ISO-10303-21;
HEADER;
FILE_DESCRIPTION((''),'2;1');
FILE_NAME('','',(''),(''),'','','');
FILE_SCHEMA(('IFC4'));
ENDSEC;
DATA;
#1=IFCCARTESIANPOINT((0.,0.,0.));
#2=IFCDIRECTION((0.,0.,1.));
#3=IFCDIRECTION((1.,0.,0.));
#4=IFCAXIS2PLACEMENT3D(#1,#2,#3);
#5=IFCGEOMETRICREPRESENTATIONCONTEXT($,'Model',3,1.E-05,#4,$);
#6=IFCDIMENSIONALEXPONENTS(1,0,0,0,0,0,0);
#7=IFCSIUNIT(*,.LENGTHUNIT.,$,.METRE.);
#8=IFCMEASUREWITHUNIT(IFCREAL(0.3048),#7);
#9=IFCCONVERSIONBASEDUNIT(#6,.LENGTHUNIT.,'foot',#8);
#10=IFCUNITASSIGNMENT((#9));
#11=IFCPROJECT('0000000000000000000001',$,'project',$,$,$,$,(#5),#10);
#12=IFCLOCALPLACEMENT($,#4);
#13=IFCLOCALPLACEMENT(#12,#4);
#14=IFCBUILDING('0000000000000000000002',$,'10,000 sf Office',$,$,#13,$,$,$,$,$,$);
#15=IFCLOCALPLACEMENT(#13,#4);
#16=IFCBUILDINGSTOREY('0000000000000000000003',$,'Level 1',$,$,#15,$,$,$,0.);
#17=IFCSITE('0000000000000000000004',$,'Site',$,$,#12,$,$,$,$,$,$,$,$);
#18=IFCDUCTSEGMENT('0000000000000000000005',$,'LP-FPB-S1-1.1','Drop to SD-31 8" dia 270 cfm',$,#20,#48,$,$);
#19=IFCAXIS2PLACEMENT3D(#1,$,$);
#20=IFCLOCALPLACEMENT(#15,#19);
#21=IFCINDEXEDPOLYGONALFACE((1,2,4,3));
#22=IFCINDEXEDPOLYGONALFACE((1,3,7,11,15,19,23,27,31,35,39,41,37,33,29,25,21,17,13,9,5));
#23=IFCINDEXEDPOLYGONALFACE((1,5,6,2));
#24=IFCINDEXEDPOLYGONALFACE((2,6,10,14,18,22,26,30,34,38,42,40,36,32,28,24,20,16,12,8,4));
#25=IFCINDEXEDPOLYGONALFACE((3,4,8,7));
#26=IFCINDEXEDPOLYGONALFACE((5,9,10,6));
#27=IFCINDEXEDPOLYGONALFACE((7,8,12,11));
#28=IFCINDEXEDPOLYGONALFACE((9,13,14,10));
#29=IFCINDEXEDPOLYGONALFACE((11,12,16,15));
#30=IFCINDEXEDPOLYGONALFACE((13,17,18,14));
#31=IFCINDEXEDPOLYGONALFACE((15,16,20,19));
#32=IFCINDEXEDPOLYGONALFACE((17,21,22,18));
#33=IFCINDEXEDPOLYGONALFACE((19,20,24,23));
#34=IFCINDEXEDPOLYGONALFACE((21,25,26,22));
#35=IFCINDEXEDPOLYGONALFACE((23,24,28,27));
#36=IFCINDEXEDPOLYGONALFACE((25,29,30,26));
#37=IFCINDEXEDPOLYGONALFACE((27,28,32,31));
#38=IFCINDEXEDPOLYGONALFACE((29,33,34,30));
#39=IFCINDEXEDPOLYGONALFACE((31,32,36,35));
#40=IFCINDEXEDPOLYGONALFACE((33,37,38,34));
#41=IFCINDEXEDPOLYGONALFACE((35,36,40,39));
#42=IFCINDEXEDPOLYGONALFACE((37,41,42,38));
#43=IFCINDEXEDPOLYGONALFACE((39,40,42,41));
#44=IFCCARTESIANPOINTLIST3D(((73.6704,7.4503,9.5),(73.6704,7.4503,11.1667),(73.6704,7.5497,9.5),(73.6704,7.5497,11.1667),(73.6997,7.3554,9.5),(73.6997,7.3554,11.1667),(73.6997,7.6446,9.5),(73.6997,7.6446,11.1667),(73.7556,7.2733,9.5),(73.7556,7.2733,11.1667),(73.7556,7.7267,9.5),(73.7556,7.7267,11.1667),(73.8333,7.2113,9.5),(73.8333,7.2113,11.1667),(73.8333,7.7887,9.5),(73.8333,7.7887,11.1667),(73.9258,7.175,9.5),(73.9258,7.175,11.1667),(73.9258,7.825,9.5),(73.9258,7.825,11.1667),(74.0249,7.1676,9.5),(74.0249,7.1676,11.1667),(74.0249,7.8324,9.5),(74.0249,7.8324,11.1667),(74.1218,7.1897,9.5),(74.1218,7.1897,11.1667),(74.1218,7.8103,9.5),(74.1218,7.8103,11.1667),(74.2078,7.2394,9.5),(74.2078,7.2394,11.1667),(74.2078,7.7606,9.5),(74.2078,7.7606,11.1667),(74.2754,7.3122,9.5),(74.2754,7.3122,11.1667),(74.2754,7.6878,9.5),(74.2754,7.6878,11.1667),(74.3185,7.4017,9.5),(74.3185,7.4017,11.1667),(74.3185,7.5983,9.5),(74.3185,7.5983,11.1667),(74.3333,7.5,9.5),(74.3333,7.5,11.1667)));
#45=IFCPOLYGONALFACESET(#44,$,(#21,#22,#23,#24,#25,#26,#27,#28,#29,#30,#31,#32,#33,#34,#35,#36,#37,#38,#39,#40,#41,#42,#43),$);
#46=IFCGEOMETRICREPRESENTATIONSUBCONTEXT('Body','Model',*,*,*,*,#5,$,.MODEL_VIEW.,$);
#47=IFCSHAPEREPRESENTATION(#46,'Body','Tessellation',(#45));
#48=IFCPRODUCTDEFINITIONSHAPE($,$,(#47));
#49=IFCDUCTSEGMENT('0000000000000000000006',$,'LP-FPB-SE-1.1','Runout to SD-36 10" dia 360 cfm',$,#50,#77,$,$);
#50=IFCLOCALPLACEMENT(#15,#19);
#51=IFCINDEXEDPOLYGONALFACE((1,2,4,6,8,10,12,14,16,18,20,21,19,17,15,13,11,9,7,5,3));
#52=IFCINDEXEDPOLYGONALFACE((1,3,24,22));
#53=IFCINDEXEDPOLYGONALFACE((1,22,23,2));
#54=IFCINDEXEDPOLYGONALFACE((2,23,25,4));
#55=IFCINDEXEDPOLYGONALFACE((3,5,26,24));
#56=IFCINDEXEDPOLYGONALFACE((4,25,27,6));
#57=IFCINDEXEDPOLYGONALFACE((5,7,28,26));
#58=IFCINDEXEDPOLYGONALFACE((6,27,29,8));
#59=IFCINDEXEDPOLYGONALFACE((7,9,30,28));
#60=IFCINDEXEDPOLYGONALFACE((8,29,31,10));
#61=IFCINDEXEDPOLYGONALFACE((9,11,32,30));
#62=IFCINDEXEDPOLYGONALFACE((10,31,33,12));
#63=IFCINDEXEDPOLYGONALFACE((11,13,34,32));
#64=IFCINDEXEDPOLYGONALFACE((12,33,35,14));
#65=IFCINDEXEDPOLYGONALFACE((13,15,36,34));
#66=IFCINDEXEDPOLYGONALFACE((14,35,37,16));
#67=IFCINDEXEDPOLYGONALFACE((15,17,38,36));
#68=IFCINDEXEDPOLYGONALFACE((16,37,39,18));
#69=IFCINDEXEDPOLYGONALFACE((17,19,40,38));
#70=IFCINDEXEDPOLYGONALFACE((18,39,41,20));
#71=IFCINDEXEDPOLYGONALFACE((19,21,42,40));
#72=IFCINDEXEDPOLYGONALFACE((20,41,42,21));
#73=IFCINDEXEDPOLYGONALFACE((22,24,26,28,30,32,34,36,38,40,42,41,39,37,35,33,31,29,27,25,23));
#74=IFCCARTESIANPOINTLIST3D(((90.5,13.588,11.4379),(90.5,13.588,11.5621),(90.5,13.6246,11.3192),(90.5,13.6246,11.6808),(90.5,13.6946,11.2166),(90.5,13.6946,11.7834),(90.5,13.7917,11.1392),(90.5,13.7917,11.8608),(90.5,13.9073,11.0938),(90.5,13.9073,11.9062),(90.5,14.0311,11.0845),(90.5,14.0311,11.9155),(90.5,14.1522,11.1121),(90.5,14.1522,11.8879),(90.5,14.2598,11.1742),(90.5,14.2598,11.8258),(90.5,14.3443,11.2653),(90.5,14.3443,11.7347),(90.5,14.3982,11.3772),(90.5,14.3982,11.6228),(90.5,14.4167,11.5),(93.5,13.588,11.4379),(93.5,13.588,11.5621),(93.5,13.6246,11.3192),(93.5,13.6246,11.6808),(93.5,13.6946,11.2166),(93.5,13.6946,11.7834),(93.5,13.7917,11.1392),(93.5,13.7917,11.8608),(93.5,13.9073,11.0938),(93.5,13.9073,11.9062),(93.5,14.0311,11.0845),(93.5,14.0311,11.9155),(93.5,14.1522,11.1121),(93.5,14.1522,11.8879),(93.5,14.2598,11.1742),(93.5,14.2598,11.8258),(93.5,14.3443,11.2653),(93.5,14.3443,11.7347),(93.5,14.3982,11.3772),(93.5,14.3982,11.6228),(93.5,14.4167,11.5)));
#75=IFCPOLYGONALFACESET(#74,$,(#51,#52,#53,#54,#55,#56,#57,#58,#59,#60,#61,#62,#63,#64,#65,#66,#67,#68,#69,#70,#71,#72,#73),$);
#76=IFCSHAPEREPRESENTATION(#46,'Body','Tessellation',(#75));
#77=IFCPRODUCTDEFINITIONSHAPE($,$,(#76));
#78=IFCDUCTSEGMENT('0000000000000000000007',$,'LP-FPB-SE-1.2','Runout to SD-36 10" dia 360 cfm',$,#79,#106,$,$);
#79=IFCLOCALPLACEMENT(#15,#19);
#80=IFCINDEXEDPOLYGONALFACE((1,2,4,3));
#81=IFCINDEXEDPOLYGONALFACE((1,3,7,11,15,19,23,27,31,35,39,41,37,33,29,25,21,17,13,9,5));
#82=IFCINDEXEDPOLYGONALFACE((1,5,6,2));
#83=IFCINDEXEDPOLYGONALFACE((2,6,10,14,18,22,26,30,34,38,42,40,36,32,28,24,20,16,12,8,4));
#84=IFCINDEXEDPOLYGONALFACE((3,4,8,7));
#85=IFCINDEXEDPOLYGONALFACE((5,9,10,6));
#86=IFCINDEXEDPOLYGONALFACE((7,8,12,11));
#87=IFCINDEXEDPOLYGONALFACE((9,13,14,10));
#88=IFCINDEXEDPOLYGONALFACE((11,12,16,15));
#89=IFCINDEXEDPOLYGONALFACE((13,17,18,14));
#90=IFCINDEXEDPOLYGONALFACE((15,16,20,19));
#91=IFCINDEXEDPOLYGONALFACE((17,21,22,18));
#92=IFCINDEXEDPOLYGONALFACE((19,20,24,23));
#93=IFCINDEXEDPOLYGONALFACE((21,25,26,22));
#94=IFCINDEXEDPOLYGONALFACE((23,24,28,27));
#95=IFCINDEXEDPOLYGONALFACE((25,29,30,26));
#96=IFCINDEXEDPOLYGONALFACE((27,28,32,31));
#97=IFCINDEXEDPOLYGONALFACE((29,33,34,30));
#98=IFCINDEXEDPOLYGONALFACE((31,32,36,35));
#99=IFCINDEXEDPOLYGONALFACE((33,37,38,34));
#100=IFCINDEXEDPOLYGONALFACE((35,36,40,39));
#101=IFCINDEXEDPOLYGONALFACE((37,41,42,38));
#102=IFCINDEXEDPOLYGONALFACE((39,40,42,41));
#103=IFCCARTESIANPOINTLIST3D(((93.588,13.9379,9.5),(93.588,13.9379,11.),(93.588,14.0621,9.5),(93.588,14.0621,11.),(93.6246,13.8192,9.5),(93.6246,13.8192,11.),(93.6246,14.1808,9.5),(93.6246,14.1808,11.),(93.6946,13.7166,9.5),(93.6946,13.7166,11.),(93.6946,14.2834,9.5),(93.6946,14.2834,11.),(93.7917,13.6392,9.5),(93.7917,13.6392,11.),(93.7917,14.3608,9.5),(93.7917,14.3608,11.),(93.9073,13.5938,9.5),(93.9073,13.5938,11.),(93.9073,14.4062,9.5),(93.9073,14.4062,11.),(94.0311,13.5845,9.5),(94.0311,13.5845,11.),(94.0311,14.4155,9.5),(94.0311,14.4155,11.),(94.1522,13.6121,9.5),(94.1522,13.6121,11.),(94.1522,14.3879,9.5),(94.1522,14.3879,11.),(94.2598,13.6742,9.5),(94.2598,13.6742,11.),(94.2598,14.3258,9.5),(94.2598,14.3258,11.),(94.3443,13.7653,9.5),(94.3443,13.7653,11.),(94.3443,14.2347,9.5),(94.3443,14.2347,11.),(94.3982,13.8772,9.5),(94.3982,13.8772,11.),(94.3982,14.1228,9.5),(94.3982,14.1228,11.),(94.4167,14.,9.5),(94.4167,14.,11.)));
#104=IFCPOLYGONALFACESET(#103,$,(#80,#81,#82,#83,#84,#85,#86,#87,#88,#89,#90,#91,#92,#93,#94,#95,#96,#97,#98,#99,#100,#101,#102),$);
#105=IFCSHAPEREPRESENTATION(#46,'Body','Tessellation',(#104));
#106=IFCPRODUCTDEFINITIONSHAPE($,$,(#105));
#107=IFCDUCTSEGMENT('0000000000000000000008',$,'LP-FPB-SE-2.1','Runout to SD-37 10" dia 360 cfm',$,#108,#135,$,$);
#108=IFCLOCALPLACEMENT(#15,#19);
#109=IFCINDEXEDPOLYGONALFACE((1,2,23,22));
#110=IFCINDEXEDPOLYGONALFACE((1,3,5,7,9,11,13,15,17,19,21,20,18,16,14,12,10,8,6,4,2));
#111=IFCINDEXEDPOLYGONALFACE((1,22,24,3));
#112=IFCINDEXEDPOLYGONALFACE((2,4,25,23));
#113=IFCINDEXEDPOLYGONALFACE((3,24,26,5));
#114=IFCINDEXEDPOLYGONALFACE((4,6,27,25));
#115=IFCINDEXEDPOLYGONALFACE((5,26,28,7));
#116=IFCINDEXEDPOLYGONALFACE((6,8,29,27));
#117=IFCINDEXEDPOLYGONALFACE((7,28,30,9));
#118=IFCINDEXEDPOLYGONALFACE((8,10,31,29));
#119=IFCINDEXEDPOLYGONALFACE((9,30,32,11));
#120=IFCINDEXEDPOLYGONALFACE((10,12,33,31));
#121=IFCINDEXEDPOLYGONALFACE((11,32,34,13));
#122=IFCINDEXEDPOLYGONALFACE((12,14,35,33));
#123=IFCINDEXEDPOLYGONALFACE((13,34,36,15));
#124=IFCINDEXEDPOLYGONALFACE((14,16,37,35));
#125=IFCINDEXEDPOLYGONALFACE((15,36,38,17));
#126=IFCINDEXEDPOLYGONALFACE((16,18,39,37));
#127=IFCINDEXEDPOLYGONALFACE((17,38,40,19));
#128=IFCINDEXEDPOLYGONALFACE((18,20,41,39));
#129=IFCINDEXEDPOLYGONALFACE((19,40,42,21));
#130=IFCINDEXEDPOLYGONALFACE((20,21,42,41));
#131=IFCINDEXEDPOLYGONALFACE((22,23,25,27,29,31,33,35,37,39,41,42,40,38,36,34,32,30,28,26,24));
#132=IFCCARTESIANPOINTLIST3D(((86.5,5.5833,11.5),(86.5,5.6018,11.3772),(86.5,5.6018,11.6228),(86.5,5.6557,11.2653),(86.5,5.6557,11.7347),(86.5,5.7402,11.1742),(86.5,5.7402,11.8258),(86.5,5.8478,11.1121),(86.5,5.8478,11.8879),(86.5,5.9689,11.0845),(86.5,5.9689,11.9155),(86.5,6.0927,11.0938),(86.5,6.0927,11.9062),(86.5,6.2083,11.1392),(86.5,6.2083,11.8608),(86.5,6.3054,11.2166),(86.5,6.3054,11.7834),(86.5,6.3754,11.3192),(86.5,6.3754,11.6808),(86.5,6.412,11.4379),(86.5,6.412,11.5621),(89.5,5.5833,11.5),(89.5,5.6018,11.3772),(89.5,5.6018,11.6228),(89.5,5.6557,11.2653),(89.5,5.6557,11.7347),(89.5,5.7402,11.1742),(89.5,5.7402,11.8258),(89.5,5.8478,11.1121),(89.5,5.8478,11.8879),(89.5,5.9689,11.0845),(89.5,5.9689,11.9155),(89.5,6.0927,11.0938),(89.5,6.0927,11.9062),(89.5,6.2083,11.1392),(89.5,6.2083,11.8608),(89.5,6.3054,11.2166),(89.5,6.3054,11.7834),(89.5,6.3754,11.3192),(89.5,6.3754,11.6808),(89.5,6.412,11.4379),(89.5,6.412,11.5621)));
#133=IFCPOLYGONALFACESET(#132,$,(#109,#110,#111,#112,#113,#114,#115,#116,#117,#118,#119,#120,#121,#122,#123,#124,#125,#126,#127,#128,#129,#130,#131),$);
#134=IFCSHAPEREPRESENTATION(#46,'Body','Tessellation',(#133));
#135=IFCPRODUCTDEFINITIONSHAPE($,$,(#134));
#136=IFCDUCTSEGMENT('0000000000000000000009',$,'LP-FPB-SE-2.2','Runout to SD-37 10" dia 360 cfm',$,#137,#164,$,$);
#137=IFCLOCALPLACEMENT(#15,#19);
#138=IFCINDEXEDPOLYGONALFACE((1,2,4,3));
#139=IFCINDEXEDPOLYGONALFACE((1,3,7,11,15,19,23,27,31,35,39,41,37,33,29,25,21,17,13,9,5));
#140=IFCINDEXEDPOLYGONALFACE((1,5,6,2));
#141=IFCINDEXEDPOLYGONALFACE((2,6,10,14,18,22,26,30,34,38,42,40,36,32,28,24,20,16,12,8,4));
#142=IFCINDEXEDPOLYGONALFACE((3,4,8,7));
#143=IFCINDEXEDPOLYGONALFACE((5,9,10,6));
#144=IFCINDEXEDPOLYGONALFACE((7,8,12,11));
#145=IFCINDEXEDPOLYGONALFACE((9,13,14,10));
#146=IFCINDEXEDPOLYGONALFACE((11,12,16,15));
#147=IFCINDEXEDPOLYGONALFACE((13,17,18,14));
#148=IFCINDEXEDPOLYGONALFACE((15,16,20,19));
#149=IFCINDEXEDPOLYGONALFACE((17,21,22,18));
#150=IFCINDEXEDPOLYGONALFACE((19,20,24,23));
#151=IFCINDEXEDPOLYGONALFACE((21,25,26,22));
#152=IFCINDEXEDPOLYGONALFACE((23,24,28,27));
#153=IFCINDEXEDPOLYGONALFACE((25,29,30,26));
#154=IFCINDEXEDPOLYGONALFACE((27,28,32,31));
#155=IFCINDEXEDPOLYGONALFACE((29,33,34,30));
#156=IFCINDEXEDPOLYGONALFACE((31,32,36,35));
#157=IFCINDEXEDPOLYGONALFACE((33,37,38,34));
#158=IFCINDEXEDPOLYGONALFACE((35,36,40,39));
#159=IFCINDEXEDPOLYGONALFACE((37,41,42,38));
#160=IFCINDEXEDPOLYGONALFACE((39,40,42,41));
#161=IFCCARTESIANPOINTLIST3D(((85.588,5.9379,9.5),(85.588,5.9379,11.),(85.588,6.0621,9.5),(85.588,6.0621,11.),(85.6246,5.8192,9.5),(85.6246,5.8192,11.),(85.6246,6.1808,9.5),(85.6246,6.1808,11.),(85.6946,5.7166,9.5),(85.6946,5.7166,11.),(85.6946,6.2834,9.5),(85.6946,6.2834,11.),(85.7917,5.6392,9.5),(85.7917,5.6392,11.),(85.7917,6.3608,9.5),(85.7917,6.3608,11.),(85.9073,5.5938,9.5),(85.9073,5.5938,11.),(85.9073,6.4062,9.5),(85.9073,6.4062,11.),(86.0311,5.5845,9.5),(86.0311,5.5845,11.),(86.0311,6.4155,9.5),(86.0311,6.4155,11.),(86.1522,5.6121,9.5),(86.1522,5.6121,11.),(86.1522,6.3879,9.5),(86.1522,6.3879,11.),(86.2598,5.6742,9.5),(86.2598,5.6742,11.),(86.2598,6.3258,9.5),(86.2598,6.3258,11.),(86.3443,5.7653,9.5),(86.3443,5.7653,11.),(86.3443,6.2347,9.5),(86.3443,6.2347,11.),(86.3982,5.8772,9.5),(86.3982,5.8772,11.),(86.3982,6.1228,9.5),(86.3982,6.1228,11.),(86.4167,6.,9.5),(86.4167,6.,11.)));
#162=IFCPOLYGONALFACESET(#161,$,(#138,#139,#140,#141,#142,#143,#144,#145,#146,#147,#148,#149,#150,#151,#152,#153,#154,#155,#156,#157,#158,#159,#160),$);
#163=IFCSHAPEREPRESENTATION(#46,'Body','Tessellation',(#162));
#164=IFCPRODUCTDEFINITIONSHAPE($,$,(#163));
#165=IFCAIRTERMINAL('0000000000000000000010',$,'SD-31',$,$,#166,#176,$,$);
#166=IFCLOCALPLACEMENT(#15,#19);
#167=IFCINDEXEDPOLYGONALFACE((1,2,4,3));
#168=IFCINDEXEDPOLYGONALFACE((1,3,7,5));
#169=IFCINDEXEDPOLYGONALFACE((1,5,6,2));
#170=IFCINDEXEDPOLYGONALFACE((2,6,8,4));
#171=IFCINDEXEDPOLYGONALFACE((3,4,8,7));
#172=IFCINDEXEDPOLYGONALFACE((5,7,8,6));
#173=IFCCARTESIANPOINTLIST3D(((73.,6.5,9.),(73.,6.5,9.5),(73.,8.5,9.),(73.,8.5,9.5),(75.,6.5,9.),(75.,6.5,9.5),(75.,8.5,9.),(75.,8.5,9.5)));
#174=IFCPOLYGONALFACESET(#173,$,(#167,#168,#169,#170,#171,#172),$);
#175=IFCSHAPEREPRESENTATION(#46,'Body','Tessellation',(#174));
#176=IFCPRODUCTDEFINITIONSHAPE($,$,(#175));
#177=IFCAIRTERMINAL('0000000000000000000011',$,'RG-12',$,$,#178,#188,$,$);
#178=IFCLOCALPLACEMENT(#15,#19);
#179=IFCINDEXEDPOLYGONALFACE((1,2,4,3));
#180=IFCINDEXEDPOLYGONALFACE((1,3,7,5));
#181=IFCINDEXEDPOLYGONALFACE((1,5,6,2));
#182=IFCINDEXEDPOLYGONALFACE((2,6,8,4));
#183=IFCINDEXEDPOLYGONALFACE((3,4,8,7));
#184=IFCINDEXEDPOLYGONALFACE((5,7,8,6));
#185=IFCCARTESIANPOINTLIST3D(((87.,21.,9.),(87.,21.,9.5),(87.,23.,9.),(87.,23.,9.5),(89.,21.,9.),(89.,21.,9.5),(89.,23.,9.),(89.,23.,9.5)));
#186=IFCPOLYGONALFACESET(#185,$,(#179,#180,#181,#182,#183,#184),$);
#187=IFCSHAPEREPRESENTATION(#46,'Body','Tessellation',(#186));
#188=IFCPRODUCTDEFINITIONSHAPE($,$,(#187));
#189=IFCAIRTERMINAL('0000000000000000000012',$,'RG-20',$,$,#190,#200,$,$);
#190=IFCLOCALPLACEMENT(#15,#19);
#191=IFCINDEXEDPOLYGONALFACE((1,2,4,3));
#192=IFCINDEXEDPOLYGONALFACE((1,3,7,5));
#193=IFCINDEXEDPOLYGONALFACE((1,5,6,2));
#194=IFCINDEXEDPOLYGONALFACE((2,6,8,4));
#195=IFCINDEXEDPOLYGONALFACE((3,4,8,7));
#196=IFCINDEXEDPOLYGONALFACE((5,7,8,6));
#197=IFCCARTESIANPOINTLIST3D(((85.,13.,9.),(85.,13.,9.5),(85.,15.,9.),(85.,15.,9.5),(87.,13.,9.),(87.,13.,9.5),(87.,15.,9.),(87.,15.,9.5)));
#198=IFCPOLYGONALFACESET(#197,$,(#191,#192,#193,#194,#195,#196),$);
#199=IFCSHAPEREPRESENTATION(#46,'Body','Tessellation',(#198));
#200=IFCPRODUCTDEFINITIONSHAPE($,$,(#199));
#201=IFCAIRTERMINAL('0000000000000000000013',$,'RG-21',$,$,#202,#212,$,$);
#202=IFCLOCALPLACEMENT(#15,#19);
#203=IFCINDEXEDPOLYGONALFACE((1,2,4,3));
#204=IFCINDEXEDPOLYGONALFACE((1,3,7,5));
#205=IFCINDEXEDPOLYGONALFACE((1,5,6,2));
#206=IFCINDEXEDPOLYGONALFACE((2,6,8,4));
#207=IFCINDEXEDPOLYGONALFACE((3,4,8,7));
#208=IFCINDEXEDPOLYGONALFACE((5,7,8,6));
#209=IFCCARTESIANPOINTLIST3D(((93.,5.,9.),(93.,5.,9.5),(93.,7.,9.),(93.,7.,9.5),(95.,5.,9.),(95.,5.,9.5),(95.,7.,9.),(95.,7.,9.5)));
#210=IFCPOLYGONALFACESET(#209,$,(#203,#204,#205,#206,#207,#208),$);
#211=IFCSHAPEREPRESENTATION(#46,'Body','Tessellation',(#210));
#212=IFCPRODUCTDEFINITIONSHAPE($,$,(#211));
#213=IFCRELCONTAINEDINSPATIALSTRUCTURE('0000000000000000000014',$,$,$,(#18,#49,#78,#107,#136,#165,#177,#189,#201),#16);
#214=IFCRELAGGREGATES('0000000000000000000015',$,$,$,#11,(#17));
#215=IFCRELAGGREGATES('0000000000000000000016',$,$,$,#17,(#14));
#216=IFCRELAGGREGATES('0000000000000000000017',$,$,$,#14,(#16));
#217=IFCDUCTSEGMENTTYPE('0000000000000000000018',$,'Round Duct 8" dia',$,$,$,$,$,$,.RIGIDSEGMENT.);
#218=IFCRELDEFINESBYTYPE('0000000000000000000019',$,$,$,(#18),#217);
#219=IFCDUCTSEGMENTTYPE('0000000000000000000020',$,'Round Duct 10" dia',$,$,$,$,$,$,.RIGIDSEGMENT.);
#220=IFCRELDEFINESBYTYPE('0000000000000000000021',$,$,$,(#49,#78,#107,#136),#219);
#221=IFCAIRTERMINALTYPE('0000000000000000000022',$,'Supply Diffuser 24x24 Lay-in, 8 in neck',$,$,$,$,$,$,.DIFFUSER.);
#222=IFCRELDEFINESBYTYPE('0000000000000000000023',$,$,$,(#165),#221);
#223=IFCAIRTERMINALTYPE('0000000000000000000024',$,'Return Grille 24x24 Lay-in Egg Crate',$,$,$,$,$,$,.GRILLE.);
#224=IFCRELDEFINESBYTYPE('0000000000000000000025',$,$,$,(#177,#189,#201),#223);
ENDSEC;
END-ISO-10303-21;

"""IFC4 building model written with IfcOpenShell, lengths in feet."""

from ifc_helpers import new_model, entity, si_unit, converted_unit, frame, origin_with_axes, place, context, subcontext, project, spatial, rectangle, circle, extrude, type_object, element, save


model = new_model("IFC4")

# Units and contexts
model_context = context("Model", 3, precision=1e-05, world=origin_with_axes())
body_context = subcontext(model_context, "Body", "Model", "MODEL_VIEW")
ifc_project = project(units=[converted_unit("LENGTHUNIT", "foot", entity("IfcReal", 0.3048), si_unit("LENGTHUNIT", "METRE"), dimensions=[1, 0, 0, 0, 0, 0, 0])], contexts=[model_context])

# Site, building, storey
site_placement = place(None, origin_with_axes())
site = spatial("IfcSite", under=ifc_project, at=site_placement, Name="Site")
building_placement = place(site_placement, origin_with_axes())
building = spatial("IfcBuilding", under=site, at=building_placement, Name="10,000 sf Office")
storey_placement = place(building_placement, origin_with_axes())
storey = spatial("IfcBuildingStorey", under=building, at=storey_placement, Name="Level 1", Elevation=0.0)

# Duct segments
duct_segment_type_1 = type_object("IfcDuctSegmentType", Name="Round Duct 8\" dia", PredefinedType="RIGIDSEGMENT")
duct_segment_1_placement = place(storey_placement, frame((74.0, 7.5, 11.1667), z_axis=(0.0, 0.0, -1.0), x_axis=(1.0, 0.0, 0.0)))
element("IfcDuctSegment", 1, at=duct_segment_1_placement, inside=storey, type_object=duct_segment_type_1, Name="LP-FPB-S1-1.1", Description="Drop to SD-31 8\" dia 270 cfm", context=body_context, shape_type="SweptSolid", body=[
    extrude(circle(Radius=0.3333), None, (0.0, 0.0, 1.0), 1.6667),
])
duct_segment_type_2 = type_object("IfcDuctSegmentType", Name="Round Duct 10\" dia", PredefinedType="RIGIDSEGMENT")
duct_segment_2_placement = place(storey_placement, frame((90.5, 14.0, 11.5), z_axis=(1.0, 0.0, 0.0), x_axis=(0.0, 1.0, 0.0)))
element("IfcDuctSegment", 2, at=duct_segment_2_placement, inside=storey, type_object=duct_segment_type_2, Name="LP-FPB-SE-1.1", Description="Runout to SD-36 10\" dia 360 cfm", context=body_context, shape_type="SweptSolid", body=[
    extrude(circle(Radius=0.4167), None, (0.0, 0.0, 1.0), 3.0),
])
duct_segment_3_placement = place(storey_placement, frame((94.0, 14.0, 11.0), z_axis=(0.0, 0.0, -1.0), x_axis=(1.0, 0.0, 0.0)))
element("IfcDuctSegment", 3, at=duct_segment_3_placement, inside=storey, type_object=duct_segment_type_2, Name="LP-FPB-SE-1.2", Description="Runout to SD-36 10\" dia 360 cfm", context=body_context, shape_type="SweptSolid", body=[
    extrude(circle(Radius=0.4167), None, (0.0, 0.0, 1.0), 1.5),
])
duct_segment_4_placement = place(storey_placement, frame((89.5, 6.0, 11.5), z_axis=(-1.0, 0.0, 0.0), x_axis=(0.0, -1.0, 0.0)))
element("IfcDuctSegment", 4, at=duct_segment_4_placement, inside=storey, type_object=duct_segment_type_2, Name="LP-FPB-SE-2.1", Description="Runout to SD-37 10\" dia 360 cfm", context=body_context, shape_type="SweptSolid", body=[
    extrude(circle(Radius=0.4167), None, (0.0, 0.0, 1.0), 3.0),
])
duct_segment_5_placement = place(storey_placement, frame((86.0, 6.0, 11.0), z_axis=(0.0, 0.0, -1.0), x_axis=(1.0, 0.0, 0.0)))
element("IfcDuctSegment", 5, at=duct_segment_5_placement, inside=storey, type_object=duct_segment_type_2, Name="LP-FPB-SE-2.2", Description="Runout to SD-37 10\" dia 360 cfm", context=body_context, shape_type="SweptSolid", body=[
    extrude(circle(Radius=0.4167), None, (0.0, 0.0, 1.0), 1.5),
])

# Air terminals
air_terminal_type_1 = type_object("IfcAirTerminalType", Name="Supply Diffuser 24x24 Lay-in, 8 in neck", PredefinedType="DIFFUSER")
air_terminal_placement = place(storey_placement, frame((74.0, 7.5, 9.0), z_axis=(0.0, 0.0, 1.0), x_axis=(1.0, 0.0, 0.0)))
element("IfcAirTerminal", 6, at=air_terminal_placement, inside=storey, type_object=air_terminal_type_1, Name="SD-31", context=body_context, shape_type="SweptSolid", body=[
    extrude(rectangle(XDim=2.0, YDim=2.0), None, (0.0, 0.0, 1.0), 0.5),
])
air_terminal_type_2 = type_object("IfcAirTerminalType", Name="Return Grille 24x24 Lay-in Egg Crate", PredefinedType="GRILLE")
for number, where, z_axis, x_axis, name in (
    (7, (88.0, 22.0, 9.0), (0.0, 0.0, 1.0), (1.0, 0.0, 0.0), "RG-12"),
    (8, (86.0, 14.0, 9.0), (0.0, 0.0, 1.0), (1.0, 0.0, 0.0), "RG-20"),
    (9, (94.0, 6.0, 9.0), (0.0, 0.0, 1.0), (1.0, 0.0, 0.0), "RG-21"),
):
    element("IfcAirTerminal", number, at=place(storey_placement, frame(where, z_axis=z_axis, x_axis=x_axis)), inside=storey, type_object=air_terminal_type_2, Name=name, context=body_context, shape_type="SweptSolid", body=[
        extrude(rectangle(XDim=2.0, YDim=2.0), None, (0.0, 0.0, 1.0), 0.5),
    ])

save(model, "model.ifc")
